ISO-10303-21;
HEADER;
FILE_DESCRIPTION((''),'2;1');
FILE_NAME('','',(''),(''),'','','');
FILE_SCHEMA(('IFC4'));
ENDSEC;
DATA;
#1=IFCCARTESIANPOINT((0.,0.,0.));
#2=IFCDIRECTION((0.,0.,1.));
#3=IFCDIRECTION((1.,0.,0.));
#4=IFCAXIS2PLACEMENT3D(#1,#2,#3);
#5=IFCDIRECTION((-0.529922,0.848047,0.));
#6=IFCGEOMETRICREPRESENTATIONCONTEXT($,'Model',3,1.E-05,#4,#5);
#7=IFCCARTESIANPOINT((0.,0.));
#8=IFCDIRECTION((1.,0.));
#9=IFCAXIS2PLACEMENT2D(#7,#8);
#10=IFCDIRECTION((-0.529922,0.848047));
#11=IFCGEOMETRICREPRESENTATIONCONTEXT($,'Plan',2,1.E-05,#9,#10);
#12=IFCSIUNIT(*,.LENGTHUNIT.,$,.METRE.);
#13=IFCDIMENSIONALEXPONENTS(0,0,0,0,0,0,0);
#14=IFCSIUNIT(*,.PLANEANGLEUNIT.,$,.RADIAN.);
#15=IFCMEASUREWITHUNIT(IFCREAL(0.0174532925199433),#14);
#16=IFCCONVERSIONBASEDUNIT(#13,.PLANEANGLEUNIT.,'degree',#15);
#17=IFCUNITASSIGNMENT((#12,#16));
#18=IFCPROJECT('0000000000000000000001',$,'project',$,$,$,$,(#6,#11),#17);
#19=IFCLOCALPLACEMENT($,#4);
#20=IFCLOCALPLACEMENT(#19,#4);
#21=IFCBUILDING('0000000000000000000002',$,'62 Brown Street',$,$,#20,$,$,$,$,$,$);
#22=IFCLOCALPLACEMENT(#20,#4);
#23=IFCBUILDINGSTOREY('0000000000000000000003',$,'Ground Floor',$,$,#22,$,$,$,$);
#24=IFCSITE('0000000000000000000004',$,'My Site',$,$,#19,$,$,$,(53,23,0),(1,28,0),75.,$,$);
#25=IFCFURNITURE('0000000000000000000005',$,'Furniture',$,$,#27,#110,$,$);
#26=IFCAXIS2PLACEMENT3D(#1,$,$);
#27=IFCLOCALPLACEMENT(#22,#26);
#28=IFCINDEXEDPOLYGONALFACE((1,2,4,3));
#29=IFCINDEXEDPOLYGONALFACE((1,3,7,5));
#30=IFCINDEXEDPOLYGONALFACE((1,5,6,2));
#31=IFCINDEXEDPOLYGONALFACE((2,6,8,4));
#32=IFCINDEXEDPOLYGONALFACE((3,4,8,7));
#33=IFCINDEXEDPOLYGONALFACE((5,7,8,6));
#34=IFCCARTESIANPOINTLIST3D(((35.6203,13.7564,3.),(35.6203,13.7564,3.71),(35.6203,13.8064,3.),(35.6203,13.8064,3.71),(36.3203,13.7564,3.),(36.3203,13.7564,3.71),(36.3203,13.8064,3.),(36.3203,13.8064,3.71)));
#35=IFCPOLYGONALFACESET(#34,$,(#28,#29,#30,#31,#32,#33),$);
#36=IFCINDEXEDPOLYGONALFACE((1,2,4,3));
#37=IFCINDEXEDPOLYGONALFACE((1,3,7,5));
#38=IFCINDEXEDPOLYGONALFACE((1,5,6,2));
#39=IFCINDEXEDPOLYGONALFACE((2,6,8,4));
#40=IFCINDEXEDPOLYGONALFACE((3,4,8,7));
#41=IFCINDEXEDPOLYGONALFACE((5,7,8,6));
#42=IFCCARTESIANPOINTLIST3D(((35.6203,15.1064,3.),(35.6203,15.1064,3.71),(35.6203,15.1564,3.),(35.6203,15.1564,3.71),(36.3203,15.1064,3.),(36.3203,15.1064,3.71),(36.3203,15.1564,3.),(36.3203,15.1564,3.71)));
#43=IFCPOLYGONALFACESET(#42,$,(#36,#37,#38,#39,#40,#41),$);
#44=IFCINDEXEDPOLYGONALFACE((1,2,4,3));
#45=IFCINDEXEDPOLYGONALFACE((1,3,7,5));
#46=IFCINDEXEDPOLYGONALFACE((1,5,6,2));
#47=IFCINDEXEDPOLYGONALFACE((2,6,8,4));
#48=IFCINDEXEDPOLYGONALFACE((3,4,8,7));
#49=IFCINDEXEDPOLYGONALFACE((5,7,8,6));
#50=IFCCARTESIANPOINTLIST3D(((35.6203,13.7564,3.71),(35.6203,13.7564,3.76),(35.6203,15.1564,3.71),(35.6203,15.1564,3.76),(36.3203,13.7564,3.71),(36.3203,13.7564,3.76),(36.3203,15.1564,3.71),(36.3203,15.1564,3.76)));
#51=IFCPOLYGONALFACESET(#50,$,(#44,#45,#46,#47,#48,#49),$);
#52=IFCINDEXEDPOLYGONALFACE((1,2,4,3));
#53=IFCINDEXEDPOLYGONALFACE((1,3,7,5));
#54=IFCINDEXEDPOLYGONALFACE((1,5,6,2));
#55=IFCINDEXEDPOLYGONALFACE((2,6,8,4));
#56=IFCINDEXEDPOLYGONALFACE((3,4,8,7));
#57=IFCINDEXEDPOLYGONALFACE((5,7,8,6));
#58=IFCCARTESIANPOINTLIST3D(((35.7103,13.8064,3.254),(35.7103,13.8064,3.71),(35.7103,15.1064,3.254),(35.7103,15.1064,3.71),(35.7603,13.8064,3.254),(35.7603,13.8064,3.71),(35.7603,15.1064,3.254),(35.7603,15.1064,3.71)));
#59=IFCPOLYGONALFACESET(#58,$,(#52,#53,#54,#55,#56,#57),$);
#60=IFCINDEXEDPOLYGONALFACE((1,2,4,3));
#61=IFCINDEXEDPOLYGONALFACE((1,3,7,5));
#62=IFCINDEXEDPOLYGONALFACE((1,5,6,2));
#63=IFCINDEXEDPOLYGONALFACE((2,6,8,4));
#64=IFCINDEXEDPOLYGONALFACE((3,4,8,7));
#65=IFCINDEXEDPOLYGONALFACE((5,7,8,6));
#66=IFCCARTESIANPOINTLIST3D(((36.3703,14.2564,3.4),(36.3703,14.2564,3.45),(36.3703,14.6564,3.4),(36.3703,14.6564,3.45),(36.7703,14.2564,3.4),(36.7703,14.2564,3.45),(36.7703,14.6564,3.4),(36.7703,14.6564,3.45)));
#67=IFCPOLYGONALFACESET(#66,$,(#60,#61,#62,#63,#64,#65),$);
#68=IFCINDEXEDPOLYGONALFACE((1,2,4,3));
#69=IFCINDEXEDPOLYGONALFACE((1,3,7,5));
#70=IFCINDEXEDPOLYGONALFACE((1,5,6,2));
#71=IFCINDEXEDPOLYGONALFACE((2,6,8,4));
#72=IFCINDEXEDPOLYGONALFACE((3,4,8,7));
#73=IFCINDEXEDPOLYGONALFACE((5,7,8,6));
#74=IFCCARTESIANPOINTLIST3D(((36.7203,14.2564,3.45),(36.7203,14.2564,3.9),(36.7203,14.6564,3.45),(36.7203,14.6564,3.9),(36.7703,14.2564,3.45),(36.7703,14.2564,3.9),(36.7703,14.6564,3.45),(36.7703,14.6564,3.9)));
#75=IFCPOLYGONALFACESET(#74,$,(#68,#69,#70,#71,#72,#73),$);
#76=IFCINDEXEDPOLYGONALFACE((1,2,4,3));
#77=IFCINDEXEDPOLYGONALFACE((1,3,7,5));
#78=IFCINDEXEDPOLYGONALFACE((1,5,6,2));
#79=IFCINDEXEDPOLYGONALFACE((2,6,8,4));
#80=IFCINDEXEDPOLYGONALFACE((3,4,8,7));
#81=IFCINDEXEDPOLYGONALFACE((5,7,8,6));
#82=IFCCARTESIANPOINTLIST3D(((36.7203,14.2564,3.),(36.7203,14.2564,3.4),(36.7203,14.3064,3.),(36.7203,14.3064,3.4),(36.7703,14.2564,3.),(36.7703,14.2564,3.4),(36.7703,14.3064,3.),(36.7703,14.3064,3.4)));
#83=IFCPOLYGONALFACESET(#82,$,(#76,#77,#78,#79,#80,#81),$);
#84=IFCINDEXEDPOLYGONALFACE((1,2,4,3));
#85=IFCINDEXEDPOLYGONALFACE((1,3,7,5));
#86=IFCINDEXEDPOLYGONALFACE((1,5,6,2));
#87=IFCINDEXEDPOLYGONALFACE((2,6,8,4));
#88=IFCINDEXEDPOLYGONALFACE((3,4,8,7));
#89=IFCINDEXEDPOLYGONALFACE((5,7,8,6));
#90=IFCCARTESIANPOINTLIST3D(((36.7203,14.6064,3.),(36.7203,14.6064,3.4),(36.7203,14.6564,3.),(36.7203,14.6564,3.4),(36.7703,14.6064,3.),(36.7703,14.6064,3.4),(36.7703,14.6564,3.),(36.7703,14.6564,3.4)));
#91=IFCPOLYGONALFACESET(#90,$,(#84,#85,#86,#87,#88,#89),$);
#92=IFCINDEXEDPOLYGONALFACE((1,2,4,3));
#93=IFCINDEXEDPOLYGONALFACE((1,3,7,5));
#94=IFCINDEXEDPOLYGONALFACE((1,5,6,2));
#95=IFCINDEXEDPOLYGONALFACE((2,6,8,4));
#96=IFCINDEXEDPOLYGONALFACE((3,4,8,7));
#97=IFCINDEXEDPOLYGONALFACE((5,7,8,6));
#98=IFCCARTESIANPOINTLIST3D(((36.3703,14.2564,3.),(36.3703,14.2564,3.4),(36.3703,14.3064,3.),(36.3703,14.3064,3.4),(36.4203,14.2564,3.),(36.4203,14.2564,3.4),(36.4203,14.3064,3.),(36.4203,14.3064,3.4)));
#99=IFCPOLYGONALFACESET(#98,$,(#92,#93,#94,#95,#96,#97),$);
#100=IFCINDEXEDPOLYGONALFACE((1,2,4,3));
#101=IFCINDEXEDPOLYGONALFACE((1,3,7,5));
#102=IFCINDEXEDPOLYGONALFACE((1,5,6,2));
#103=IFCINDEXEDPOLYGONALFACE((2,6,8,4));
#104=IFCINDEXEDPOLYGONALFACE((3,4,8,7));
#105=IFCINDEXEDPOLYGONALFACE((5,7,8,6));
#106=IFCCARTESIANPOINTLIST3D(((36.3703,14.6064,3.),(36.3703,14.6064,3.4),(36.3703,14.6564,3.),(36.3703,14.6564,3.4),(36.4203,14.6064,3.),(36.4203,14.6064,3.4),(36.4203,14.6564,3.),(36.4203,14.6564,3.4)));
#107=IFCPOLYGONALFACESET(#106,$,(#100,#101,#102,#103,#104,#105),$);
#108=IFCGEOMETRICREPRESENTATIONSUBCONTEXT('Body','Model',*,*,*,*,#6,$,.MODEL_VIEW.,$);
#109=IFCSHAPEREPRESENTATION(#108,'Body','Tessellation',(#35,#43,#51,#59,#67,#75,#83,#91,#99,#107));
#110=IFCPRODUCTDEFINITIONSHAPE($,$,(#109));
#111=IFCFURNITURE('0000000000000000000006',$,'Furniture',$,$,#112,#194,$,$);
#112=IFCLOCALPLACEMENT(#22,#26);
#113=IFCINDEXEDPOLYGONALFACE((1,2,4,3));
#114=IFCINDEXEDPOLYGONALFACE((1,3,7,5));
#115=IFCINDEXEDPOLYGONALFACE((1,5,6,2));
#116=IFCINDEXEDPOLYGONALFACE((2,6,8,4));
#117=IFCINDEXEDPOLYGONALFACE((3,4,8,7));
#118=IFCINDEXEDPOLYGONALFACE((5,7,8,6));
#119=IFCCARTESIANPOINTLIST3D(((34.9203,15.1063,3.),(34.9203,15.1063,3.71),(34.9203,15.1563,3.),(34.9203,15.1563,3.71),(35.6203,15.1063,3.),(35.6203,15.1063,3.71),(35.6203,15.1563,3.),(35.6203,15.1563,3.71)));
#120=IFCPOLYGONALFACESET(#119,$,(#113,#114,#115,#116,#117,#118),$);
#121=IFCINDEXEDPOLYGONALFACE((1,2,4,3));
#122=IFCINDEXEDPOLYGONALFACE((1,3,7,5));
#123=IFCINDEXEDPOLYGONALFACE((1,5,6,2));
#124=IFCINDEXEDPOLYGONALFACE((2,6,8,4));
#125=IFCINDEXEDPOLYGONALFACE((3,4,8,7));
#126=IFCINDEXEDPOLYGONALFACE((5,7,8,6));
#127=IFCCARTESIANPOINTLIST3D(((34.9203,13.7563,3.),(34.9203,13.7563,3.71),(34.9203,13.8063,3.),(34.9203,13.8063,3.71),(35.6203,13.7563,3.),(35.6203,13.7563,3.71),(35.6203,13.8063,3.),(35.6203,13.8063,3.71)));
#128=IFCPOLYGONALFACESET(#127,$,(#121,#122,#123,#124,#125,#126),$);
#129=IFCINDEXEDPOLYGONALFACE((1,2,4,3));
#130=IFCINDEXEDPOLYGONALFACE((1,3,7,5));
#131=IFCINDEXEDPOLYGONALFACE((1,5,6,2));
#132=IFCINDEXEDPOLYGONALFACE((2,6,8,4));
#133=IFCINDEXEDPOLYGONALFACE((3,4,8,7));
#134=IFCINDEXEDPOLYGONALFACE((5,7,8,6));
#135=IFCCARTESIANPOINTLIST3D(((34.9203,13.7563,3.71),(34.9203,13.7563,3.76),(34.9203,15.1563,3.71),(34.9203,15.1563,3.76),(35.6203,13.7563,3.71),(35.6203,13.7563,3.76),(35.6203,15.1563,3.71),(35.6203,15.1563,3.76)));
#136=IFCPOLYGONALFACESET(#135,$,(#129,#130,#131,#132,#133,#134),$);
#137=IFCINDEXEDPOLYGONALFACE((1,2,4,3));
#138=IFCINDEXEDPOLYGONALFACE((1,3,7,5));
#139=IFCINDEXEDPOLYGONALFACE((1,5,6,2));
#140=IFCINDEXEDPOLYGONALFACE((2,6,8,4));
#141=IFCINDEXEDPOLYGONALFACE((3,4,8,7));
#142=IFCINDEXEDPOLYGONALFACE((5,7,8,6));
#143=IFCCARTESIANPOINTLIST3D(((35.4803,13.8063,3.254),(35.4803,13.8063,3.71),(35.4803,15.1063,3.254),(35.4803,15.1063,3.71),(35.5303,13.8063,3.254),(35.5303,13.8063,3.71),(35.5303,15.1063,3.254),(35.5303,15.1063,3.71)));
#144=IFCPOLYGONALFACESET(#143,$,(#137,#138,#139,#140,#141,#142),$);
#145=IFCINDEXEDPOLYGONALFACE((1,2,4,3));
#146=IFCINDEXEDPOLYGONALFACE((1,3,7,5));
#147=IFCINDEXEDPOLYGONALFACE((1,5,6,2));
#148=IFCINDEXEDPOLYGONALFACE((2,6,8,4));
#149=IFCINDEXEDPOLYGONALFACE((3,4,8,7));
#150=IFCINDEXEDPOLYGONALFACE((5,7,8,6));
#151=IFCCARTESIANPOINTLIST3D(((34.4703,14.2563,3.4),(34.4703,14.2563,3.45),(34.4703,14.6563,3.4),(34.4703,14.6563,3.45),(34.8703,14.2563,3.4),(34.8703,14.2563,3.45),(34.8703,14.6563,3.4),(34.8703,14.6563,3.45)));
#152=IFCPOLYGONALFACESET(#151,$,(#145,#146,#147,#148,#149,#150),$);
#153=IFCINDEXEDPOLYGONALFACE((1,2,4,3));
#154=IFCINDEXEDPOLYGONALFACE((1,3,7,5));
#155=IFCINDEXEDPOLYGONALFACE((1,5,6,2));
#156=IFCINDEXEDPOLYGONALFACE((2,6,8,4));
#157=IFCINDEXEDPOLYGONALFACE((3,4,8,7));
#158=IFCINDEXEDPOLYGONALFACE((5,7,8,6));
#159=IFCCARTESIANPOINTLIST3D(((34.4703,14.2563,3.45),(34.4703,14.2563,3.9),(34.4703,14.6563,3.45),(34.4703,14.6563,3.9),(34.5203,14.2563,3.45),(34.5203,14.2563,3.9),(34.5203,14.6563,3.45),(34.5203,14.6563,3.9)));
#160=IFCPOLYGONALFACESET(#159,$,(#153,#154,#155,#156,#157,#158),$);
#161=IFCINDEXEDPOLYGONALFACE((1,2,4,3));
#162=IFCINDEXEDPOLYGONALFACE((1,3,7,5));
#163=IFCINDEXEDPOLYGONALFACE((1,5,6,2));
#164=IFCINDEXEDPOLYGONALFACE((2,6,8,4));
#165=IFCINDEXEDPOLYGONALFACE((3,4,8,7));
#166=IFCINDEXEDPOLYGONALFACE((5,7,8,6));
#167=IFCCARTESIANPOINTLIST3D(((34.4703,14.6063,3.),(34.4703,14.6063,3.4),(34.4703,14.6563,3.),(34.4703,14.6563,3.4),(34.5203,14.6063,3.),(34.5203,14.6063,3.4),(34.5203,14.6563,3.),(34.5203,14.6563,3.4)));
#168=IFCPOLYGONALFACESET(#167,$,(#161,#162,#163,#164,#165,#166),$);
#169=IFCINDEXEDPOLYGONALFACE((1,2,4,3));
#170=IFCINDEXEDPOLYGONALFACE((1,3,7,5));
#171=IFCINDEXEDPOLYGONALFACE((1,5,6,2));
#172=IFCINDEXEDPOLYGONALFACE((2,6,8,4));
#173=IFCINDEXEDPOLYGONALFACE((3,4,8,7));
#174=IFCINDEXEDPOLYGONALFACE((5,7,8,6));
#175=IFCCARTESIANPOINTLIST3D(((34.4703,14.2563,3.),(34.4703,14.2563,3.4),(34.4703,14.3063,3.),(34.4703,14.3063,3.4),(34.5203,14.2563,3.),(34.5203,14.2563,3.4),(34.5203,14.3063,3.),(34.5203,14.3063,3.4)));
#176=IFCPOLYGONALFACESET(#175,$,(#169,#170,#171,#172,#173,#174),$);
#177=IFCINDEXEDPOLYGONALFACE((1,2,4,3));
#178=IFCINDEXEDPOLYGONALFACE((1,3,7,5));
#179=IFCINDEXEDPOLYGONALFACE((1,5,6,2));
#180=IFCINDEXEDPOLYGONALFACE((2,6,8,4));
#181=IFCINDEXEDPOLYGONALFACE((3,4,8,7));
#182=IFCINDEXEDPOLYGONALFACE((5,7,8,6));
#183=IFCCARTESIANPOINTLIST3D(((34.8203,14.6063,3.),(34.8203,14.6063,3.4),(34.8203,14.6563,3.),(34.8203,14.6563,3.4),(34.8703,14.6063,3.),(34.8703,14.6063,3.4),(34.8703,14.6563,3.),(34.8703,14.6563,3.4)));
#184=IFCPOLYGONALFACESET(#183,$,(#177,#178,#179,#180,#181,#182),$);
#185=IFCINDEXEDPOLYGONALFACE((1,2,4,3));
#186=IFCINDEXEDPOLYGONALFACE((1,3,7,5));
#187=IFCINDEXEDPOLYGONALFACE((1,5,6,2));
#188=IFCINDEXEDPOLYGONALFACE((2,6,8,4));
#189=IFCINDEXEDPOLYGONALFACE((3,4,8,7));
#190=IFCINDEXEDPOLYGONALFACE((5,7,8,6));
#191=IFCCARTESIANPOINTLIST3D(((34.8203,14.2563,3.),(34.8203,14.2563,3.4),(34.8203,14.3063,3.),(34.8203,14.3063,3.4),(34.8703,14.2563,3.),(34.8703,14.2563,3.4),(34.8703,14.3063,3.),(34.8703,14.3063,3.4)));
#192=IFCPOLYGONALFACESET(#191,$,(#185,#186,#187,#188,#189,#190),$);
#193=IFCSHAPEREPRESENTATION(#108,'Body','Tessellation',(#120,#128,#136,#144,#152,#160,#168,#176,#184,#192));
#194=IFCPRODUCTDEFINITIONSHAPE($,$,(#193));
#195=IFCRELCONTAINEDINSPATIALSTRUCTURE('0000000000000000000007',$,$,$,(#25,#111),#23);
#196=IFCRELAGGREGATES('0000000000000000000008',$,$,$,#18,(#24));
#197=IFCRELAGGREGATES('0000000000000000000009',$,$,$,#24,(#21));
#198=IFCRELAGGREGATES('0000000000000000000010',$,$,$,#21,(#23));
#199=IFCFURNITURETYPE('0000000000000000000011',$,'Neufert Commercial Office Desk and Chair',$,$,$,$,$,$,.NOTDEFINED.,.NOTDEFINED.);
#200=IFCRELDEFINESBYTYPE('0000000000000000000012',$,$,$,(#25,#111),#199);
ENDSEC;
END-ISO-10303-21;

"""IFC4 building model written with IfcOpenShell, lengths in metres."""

from ifc_helpers import new_model, entity, si_unit, converted_unit, direction, frame, origin_with_axes, origin_2d_with_axis, place, context, subcontext, project, spatial, line, indexed_curve, outline, extrude, shape, source, transform, mapped, type_object, type_shapes, element, save


model = new_model("IFC4")

# Units and contexts
model_context = context("Model", 3, precision=1e-05, world=origin_with_axes(), true_north=direction((-0.529922, 0.848047, 0.0)))
plan_context = context("Plan", 2, precision=1e-05, world=origin_2d_with_axis(), true_north=direction((-0.529922, 0.848047)))
body_context_1 = subcontext(model_context, "Body", "Model", "MODEL_VIEW")
body_context_2 = subcontext(plan_context, "Body", "Plan", "PLAN_VIEW")
ifc_project = project(units=[si_unit("LENGTHUNIT", "METRE"), converted_unit("PLANEANGLEUNIT", "degree", entity("IfcReal", 0.0174532925199433), si_unit("PLANEANGLEUNIT", "RADIAN"), dimensions=[0, 0, 0, 0, 0, 0, 0])], contexts=[model_context, plan_context])

# Site, building, storey
site_placement = place(None, origin_with_axes())
site = spatial("IfcSite", under=ifc_project, at=site_placement, Name="My Site", RefLatitude=(53, 23, 0), RefLongitude=(1, 28, 0), RefElevation=75.0)
building_placement = place(site_placement, origin_with_axes())
building = spatial("IfcBuilding", under=site, at=building_placement, Name="62 Brown Street")
storey_placement = place(building_placement, origin_with_axes())
storey = spatial("IfcBuildingStorey", under=building, at=storey_placement, Name="Ground Floor")

# Furniture
furniture_type = type_object("IfcFurnitureType", Name="Neufert Commercial Office Desk and Chair", AssemblyPlace="NOTDEFINED", PredefinedType="NOTDEFINED")
shared_shape_1 = source(origin_with_axes(), body_context_1, "Body", "SweptSolid", [
    extrude(outline(indexed_curve([(0.0, 0.0), (0.05, 0.0), (0.05, 0.7), (0.0, 0.7)], segments=[line(1, 2, 3, 4, 1)])), frame((0.0, 0.45, 0.0), z_axis=(0.0, 0.0, 1.0), x_axis=(1.0, 0.0, 0.0)), (0.0, 0.0, 1.0), 0.71),
    extrude(outline(indexed_curve([(0.0, 0.0), (0.05, 0.0), (0.05, 0.7), (0.0, 0.7)], segments=[line(1, 2, 3, 4, 1)])), frame((1.35, 0.45, 0.0), z_axis=(0.0, 0.0, 1.0), x_axis=(1.0, 0.0, 0.0)), (0.0, 0.0, 1.0), 0.71),
    extrude(outline(indexed_curve([(0.0, 0.0), (1.4, 0.0), (1.4, 0.7), (0.0, 0.7)], segments=[line(1, 2, 3, 4, 1)])), frame((0.0, 0.45, 0.71), z_axis=(0.0, 0.0, 1.0), x_axis=(1.0, 0.0, 0.0)), (0.0, 0.0, 1.0), 0.05),
    extrude(outline(indexed_curve([(0.05, 0.56), (1.35, 0.56), (1.35, 0.61), (0.05, 0.61)], segments=[line(1, 2, 3, 4, 1)])), frame((0.0, 0.45, 0.254), z_axis=(0.0, 0.0, 1.0), x_axis=(1.0, 0.0, 0.0)), (0.0, 0.0, 1.0), 0.456),
    extrude(outline(indexed_curve([(-0.2, 0.0), (0.2, 0.0), (0.2, 0.4), (-0.2, 0.4)], segments=[line(1, 2, 3, 4, 1)])), frame((0.7, 0.0, 0.45), z_axis=(0.0, 0.0, 1.0), x_axis=(1.0, 0.0, 0.0)), (0.0, 0.0, -1.0), 0.05),
    extrude(outline(indexed_curve([(-0.2, 0.0), (0.2, 0.0), (0.2, 0.05), (-0.2, 0.05)], segments=[line(1, 2, 3, 4, 1)])), frame((0.7, 0.0, 0.9), z_axis=(0.0, 0.0, 1.0), x_axis=(1.0, 0.0, 0.0)), (0.0, 0.0, -1.0), 0.45),
    extrude(outline(indexed_curve([(-0.2, 0.0), (-0.15, 0.0), (-0.15, 0.05), (-0.2, 0.05)], segments=[line(1, 2, 3, 4, 1)])), frame((0.7, 0.0, 0.0), z_axis=(0.0, 0.0, 1.0), x_axis=(1.0, 0.0, 0.0)), (0.0, 0.0, 1.0), 0.4),
    extrude(outline(indexed_curve([(0.2, 0.0), (0.15, 0.0), (0.15, 0.05), (0.2, 0.05)], segments=[line(1, 2, 3, 4, 1)])), frame((0.7, 0.0, 0.0), z_axis=(0.0, 0.0, 1.0), x_axis=(1.0, 0.0, 0.0)), (0.0, 0.0, 1.0), 0.4),
    extrude(outline(indexed_curve([(-0.2, 0.4), (-0.15, 0.4), (-0.15, 0.35), (-0.2, 0.35)], segments=[line(1, 2, 3, 4, 1)])), frame((0.7, 0.0, 0.0), z_axis=(0.0, 0.0, 1.0), x_axis=(1.0, 0.0, 0.0)), (0.0, 0.0, 1.0), 0.4),
    extrude(outline(indexed_curve([(0.2, 0.4), (0.15, 0.4), (0.15, 0.35), (0.2, 0.35)], segments=[line(1, 2, 3, 4, 1)])), frame((0.7, 0.0, 0.0), z_axis=(0.0, 0.0, 1.0), x_axis=(1.0, 0.0, 0.0)), (0.0, 0.0, 1.0), 0.4),
])
shared_shape_2 = source(origin_with_axes(), body_context_2, "Body", "Curve2D", [
    entity("IfcIndexedPolyCurve", entity("IfcCartesianPointList2D", [[0.0, 0.45], [1.4, 0.45], [1.4, 1.15], [0.0, 1.15]]), [entity("IfcLineIndex", [1, 2, 3, 4, 1])]),
    entity("IfcIndexedPolyCurve", entity("IfcCartesianPointList2D", [[0.5, 0.4], [0.9, 0.4]])),
    entity("IfcIndexedPolyCurve", entity("IfcCartesianPointList2D", [[0.5, 0.4], [0.5, 0.2], [0.5586, 0.0586], [0.7, 0.0], [0.8414, 0.0586], [0.9, 0.2], [0.9, 0.4]]), [entity("IfcLineIndex", [1, 2]), entity("IfcArcIndex", [2, 3, 4]), entity("IfcArcIndex", [4, 5, 6]), entity("IfcLineIndex", [6, 7])]),
    entity("IfcIndexedPolyCurve", entity("IfcCartesianPointList2D", [[0.54, 0.4], [0.54, 0.2], [0.5869, 0.0869], [0.7, 0.04], [0.8131, 0.0869], [0.86, 0.2], [0.86, 0.4]]), [entity("IfcLineIndex", [1, 2]), entity("IfcArcIndex", [2, 3, 4]), entity("IfcArcIndex", [4, 5, 6]), entity("IfcLineIndex", [6, 7])]),
])
type_shapes(furniture_type, [shared_shape_1, shared_shape_2])
for number, where, z_axis, x_axis, name in (
    (1, (36.7703, 13.7564, 3.0), (0.0, 0.0, 1.0), (0.0, 1.0, 0.0), "Furniture"),
    (2, (34.4703, 15.1563, 3.0), (0.0, 0.0, 1.0), (0.0, -1.0, 0.0), "Furniture"),
):
    element("IfcFurniture", number, at=place(storey_placement, frame(where, z_axis=z_axis, x_axis=x_axis)), inside=storey, type_object=furniture_type, Name=name, shapes=[
        shape(body_context_1, "Body", "MappedRepresentation", [mapped(shared_shape_1, transform((0.0, 0.0, 0.0), x_axis=(1.0, 0.0, 0.0), y_axis=(0.0, 1.0, 0.0), z_axis=(0.0, 0.0, 1.0), scale=1.0))]),
        shape(body_context_2, "Body", "MappedRepresentation", [mapped(shared_shape_2, transform((0.0, 0.0, 0.0), x_axis=(1.0, 0.0, 0.0), y_axis=(0.0, 1.0, 0.0), z_axis=(0.0, 0.0, 1.0), scale=1.0))]),
    ])

save(model, "model.ifc")
